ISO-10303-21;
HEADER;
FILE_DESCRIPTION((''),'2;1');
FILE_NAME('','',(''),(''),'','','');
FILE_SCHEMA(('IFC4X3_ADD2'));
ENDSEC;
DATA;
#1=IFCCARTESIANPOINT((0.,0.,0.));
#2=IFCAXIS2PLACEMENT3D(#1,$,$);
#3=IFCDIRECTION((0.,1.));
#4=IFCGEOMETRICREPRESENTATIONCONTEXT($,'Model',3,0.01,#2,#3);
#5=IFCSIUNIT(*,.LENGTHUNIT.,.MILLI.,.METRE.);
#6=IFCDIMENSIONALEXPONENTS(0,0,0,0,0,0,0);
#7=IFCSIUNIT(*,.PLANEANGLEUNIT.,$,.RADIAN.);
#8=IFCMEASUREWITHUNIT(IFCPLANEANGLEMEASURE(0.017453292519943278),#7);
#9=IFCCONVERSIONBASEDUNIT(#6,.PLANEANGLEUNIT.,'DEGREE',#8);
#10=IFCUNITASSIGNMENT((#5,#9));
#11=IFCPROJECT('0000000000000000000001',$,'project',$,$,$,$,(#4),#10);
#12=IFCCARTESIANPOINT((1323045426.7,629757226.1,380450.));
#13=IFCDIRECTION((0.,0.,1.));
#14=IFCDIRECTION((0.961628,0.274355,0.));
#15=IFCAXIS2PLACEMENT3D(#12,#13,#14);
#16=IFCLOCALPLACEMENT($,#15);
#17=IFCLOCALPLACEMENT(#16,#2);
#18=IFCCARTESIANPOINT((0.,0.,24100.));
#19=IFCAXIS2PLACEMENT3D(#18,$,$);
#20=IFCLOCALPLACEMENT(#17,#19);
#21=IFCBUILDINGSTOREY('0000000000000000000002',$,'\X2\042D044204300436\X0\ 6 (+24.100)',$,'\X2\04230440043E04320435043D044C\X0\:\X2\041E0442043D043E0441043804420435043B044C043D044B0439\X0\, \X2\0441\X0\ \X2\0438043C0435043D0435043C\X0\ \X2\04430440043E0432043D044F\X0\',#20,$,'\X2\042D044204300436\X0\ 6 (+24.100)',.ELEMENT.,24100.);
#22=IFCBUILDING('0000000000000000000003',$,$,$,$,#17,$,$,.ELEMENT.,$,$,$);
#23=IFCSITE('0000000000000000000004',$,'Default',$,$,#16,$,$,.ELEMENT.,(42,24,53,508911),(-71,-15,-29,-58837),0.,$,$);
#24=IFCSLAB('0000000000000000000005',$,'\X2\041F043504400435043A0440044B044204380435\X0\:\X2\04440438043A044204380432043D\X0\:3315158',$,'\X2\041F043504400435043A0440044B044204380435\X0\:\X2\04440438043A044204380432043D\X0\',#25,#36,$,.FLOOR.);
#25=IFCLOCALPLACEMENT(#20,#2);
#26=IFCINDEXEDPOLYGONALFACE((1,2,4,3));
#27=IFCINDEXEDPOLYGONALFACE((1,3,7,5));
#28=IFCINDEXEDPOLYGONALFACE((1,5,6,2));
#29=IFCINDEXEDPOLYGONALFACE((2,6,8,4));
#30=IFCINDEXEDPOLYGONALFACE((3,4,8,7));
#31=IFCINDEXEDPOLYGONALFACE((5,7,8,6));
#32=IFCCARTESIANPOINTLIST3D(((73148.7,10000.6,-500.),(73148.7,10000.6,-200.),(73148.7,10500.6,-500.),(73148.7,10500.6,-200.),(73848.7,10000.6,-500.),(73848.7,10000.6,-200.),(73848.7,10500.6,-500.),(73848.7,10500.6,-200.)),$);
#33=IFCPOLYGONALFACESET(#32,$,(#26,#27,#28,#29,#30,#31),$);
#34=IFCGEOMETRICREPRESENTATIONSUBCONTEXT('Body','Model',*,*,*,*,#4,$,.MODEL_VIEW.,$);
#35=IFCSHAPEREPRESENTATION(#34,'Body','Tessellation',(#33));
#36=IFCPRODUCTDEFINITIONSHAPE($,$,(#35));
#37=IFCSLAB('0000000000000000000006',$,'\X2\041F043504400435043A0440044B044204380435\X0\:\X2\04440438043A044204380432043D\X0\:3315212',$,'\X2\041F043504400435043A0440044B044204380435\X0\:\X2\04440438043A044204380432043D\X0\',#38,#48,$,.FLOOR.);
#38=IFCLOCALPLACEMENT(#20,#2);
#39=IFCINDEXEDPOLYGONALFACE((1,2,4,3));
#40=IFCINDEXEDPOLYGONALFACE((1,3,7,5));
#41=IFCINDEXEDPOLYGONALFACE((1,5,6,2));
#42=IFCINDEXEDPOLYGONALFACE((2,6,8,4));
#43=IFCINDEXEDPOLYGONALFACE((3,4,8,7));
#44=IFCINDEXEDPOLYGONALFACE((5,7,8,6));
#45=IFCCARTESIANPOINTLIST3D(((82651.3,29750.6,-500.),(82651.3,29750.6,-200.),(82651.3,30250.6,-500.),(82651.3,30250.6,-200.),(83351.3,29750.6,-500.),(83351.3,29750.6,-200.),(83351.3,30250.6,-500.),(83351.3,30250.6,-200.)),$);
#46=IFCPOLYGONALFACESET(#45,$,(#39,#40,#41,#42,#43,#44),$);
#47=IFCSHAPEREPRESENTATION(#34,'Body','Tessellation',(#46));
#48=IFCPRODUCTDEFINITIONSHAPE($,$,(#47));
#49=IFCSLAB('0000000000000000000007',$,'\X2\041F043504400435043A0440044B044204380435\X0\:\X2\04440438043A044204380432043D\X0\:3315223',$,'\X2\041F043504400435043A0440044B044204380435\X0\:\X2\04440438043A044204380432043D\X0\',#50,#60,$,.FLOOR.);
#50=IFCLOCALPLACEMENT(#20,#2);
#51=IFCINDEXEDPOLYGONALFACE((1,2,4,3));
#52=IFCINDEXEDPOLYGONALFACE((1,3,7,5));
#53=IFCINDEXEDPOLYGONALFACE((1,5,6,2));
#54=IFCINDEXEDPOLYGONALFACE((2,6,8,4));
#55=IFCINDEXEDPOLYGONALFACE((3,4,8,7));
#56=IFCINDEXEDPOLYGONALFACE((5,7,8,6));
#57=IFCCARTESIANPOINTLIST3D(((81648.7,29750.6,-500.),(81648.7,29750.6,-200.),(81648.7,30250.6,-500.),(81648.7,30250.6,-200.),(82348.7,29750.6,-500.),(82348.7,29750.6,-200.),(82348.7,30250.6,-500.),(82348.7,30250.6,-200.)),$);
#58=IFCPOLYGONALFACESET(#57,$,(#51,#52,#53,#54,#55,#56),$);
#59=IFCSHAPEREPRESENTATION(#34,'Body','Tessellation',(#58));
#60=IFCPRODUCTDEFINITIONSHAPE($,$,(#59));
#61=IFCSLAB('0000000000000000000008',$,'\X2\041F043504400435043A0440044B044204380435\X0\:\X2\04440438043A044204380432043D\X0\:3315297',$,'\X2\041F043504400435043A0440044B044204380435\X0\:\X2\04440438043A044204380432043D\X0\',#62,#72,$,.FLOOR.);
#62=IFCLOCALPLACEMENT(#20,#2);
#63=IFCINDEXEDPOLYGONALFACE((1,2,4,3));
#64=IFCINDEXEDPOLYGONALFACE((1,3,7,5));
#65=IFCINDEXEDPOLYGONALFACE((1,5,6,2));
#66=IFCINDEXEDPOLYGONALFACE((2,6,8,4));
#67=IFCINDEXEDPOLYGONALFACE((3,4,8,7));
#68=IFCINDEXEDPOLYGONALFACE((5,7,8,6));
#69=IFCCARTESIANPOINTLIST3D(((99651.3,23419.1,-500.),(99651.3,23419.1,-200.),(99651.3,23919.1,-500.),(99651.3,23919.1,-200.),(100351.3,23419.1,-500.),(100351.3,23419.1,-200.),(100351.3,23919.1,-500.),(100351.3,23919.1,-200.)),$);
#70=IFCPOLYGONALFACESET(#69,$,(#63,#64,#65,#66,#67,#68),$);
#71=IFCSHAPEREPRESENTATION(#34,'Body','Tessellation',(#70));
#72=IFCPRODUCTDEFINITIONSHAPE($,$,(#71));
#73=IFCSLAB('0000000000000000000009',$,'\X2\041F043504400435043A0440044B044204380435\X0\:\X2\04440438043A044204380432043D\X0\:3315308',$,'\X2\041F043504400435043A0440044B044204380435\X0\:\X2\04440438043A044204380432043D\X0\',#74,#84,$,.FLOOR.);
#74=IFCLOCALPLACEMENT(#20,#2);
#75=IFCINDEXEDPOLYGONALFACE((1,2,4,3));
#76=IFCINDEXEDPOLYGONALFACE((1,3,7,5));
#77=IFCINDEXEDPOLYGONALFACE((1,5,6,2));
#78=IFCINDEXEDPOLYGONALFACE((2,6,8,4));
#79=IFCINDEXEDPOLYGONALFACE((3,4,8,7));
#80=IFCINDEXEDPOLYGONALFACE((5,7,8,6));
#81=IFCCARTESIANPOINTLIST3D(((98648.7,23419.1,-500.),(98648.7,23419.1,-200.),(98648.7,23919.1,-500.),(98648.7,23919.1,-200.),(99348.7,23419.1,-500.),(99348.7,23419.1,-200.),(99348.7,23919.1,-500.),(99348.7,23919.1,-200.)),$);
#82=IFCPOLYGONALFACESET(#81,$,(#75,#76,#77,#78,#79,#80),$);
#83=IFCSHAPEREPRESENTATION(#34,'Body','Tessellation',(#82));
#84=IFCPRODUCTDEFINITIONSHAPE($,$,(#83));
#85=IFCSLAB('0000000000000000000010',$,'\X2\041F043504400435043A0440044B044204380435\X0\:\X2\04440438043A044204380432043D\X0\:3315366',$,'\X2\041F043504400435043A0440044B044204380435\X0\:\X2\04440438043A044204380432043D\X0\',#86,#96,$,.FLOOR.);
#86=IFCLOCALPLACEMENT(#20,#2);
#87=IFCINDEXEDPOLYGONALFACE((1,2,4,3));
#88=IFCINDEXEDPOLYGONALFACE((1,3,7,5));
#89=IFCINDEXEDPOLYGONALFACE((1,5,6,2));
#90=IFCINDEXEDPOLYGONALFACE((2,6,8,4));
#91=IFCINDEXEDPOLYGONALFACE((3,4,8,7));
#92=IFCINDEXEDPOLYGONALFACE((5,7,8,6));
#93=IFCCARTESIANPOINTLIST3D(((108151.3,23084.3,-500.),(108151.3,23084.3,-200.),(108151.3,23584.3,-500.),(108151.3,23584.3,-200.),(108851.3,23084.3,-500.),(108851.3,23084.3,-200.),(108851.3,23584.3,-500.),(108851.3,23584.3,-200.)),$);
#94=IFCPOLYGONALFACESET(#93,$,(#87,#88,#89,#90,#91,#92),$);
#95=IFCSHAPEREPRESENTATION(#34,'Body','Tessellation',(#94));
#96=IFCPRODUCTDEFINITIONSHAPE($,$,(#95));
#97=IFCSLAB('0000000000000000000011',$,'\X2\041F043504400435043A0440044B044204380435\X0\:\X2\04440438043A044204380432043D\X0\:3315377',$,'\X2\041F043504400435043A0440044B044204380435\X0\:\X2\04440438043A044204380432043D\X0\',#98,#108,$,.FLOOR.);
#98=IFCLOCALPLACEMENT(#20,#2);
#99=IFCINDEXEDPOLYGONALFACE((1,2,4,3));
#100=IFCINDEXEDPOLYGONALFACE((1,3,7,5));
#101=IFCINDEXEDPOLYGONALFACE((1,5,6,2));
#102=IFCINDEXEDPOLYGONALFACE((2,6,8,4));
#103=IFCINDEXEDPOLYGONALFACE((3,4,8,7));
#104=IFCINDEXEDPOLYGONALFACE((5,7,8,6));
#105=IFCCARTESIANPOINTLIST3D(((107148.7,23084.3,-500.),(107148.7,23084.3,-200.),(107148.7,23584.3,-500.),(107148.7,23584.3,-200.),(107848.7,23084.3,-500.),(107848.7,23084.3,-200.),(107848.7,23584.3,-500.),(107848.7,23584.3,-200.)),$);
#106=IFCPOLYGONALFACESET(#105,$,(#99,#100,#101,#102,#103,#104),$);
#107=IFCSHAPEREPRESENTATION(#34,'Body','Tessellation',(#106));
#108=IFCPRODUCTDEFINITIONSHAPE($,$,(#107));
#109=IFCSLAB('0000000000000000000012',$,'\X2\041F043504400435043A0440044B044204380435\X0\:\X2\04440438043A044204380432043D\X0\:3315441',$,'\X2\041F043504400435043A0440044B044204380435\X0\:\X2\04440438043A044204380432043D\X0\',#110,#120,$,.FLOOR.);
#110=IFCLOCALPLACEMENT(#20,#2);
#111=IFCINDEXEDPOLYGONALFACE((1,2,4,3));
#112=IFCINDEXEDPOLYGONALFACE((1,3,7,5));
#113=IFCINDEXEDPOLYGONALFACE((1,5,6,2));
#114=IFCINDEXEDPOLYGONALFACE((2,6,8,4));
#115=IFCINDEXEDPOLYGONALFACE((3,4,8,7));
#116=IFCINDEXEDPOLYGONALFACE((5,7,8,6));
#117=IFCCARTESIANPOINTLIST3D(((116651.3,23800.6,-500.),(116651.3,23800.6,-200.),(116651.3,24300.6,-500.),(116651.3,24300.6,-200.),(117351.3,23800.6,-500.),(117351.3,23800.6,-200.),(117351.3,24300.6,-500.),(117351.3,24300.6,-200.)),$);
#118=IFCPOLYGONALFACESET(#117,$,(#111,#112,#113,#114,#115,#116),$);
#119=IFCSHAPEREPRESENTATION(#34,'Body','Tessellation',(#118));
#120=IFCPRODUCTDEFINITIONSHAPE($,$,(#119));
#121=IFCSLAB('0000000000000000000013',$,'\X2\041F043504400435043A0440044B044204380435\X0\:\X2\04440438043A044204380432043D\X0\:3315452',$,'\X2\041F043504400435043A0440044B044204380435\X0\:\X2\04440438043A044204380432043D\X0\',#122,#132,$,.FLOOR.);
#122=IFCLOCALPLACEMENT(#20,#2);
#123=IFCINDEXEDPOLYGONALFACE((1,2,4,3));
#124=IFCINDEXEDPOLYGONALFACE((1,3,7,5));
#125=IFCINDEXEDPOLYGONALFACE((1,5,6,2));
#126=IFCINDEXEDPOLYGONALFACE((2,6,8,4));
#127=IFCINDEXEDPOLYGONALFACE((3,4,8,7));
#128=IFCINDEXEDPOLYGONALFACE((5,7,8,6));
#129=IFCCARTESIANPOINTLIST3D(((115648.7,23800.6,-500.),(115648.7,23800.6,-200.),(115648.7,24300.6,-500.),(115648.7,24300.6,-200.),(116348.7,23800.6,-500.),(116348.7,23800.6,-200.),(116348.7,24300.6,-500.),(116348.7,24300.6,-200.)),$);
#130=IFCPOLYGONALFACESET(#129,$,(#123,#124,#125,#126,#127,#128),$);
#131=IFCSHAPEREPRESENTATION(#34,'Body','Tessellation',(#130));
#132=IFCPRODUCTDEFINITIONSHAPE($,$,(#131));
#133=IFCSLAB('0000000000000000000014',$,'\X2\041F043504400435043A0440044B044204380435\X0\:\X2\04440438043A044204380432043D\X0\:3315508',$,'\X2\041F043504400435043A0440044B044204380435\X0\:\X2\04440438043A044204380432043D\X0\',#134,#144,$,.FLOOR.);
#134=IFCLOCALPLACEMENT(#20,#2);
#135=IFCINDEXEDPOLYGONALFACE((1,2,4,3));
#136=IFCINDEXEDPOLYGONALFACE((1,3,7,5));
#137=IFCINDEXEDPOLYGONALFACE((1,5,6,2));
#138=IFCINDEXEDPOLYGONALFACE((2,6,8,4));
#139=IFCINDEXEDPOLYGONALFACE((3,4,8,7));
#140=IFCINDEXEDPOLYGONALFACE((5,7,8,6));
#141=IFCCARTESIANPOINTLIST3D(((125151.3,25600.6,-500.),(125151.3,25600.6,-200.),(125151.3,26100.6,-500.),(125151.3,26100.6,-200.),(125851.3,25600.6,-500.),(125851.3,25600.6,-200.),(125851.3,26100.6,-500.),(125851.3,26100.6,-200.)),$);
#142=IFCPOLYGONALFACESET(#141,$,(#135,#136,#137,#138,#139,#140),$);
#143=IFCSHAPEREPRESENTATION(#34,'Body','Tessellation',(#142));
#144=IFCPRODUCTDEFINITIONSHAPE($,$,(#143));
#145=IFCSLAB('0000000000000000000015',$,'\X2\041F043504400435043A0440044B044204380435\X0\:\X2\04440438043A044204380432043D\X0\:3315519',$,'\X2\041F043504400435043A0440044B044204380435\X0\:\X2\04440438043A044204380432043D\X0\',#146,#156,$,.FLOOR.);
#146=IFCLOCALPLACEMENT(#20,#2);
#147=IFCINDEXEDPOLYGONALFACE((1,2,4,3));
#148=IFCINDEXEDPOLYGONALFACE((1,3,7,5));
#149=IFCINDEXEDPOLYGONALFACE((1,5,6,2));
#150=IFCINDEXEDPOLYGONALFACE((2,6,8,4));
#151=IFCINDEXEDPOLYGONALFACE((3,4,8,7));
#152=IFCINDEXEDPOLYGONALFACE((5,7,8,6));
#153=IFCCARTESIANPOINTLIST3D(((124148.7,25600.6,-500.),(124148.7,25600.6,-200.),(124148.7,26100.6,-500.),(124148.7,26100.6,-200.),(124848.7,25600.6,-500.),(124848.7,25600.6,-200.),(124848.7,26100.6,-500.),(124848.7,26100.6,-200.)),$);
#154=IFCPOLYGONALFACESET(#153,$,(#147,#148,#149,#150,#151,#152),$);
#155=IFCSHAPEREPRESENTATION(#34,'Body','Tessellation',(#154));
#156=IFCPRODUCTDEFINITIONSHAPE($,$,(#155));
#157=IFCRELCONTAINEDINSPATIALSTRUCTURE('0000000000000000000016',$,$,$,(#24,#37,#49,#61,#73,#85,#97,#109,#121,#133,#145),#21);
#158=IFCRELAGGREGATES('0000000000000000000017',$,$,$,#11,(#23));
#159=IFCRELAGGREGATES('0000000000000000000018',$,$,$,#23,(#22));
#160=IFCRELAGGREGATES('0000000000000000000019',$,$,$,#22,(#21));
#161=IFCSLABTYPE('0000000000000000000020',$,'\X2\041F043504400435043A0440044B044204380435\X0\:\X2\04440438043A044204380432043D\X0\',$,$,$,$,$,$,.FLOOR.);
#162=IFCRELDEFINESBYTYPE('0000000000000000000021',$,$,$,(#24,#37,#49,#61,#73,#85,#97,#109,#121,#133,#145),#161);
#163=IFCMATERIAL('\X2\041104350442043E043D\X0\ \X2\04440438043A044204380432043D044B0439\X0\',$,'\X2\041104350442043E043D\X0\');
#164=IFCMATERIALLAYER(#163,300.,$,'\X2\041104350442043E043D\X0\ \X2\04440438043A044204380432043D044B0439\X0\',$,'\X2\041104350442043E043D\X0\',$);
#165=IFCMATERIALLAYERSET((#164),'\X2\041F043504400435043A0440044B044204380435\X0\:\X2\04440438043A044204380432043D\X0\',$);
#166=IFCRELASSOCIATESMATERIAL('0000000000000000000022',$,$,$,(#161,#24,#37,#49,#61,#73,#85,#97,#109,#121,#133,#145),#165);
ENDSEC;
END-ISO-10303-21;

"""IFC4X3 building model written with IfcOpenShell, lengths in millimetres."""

from ifc_helpers import new_model, entity, si_unit, converted_unit, direction, frame, frame_2d, origin, place, context, subcontext, project, spatial, rectangle, extrude, material, layer, layer_set, layer_usage, type_object, element, save


model = new_model("IFC4X3")

# Units and contexts
model_context = context("Model", 3, precision=0.01, world=origin(), true_north=direction((0.0, 1.0)))
body_context = subcontext(model_context, "Body", "Model", "MODEL_VIEW")
ifc_project = project(units=[si_unit("LENGTHUNIT", "METRE", prefix="MILLI"), converted_unit("PLANEANGLEUNIT", "DEGREE", entity("IfcPlaneAngleMeasure", 0.017453292519943278), si_unit("PLANEANGLEUNIT", "RADIAN"), dimensions=[0, 0, 0, 0, 0, 0, 0])], contexts=[model_context])

# Site, building, storey
site_placement = place(None, frame((1323045426.7, 629757226.1, 380450.0), z_axis=(0.0, 0.0, 1.0), x_axis=(0.961628, 0.274355, 0.0)))
site = spatial("IfcSite", under=ifc_project, at=site_placement, Name="Default", CompositionType="ELEMENT", RefLatitude=(42, 24, 53, 508911), RefLongitude=(-71, -15, -29, -58837), RefElevation=0.0)
building_placement = place(site_placement, origin())
building = spatial("IfcBuilding", under=site, at=building_placement, CompositionType="ELEMENT")
storey_placement = place(building_placement, frame((0.0, 0.0, 24100.0)))
storey = spatial("IfcBuildingStorey", under=building, at=storey_placement, Name="Этаж 6 (+24.100)", ObjectType="Уровень:Относительный, с именем уровня", LongName="Этаж 6 (+24.100)", CompositionType="ELEMENT", Elevation=24100.0)

# Slabs
ifc_material = material(Name="Бетон фиктивный", Category="Бетон")
ifc_layer = layer(ifc_material, 300.0, Name="Бетон фиктивный", Category="Бетон")
ifc_layer_set = layer_set([ifc_layer], Name="Перекрытие:фиктивн")
slab_type = type_object("IfcSlabType", Name="Перекрытие:фиктивн", PredefinedType="FLOOR", material=ifc_layer_set)
ifc_layer_usage_1 = layer_usage(ifc_layer_set, "AXIS3", "POSITIVE", 0.0)
slab_1_placement = place(storey_placement, origin())
element("IfcSlab", 1, at=slab_1_placement, inside=storey, type_object=slab_type, material=ifc_layer_usage_1, Name="Перекрытие:фиктивн:3315158", ObjectType="Перекрытие:фиктивн", PredefinedType="FLOOR", context=body_context, shape_type="SweptSolid", body=[
    extrude(rectangle(XDim=500.0, YDim=700.0, at=frame_2d((0.0, 0.0), x_axis=(1.0, 0.0))), frame((73498.7, 10250.6, -200.0), z_axis=(0.0, 0.0, -1.0), x_axis=(0.0, 1.0, 0.0)), (0.0, 0.0, 1.0), 300.0),
])
ifc_layer_usage_2 = layer_usage(ifc_layer_set, "AXIS3", "POSITIVE", 0.0)
slab_2_placement = place(storey_placement, origin())
element("IfcSlab", 2, at=slab_2_placement, inside=storey, type_object=slab_type, material=ifc_layer_usage_2, Name="Перекрытие:фиктивн:3315212", ObjectType="Перекрытие:фиктивн", PredefinedType="FLOOR", context=body_context, shape_type="SweptSolid", body=[
    extrude(rectangle(XDim=500.0, YDim=700.0, at=frame_2d((0.0, 0.0), x_axis=(1.0, 0.0))), frame((83001.3, 30000.6, -200.0), z_axis=(0.0, 0.0, -1.0), x_axis=(0.0, 1.0, 0.0)), (0.0, 0.0, 1.0), 300.0),
])
ifc_layer_usage_3 = layer_usage(ifc_layer_set, "AXIS3", "POSITIVE", 0.0)
slab_3_placement = place(storey_placement, origin())
element("IfcSlab", 3, at=slab_3_placement, inside=storey, type_object=slab_type, material=ifc_layer_usage_3, Name="Перекрытие:фиктивн:3315223", ObjectType="Перекрытие:фиктивн", PredefinedType="FLOOR", context=body_context, shape_type="SweptSolid", body=[
    extrude(rectangle(XDim=500.0, YDim=700.0, at=frame_2d((0.0, 0.0), x_axis=(1.0, 0.0))), frame((81998.7, 30000.6, -200.0), z_axis=(0.0, 0.0, -1.0), x_axis=(0.0, 1.0, 0.0)), (0.0, 0.0, 1.0), 300.0),
])
ifc_layer_usage_4 = layer_usage(ifc_layer_set, "AXIS3", "POSITIVE", 0.0)
slab_4_placement = place(storey_placement, origin())
element("IfcSlab", 4, at=slab_4_placement, inside=storey, type_object=slab_type, material=ifc_layer_usage_4, Name="Перекрытие:фиктивн:3315297", ObjectType="Перекрытие:фиктивн", PredefinedType="FLOOR", context=body_context, shape_type="SweptSolid", body=[
    extrude(rectangle(XDim=500.0, YDim=700.0, at=frame_2d((0.0, 0.0), x_axis=(1.0, 0.0))), frame((100001.3, 23669.1, -200.0), z_axis=(0.0, 0.0, -1.0), x_axis=(0.0, 1.0, 0.0)), (0.0, 0.0, 1.0), 300.0),
])
ifc_layer_usage_5 = layer_usage(ifc_layer_set, "AXIS3", "POSITIVE", 0.0)
slab_5_placement = place(storey_placement, origin())
element("IfcSlab", 5, at=slab_5_placement, inside=storey, type_object=slab_type, material=ifc_layer_usage_5, Name="Перекрытие:фиктивн:3315308", ObjectType="Перекрытие:фиктивн", PredefinedType="FLOOR", context=body_context, shape_type="SweptSolid", body=[
    extrude(rectangle(XDim=500.0, YDim=700.0, at=frame_2d((0.0, 0.0), x_axis=(1.0, 0.0))), frame((98998.7, 23669.1, -200.0), z_axis=(0.0, 0.0, -1.0), x_axis=(0.0, 1.0, 0.0)), (0.0, 0.0, 1.0), 300.0),
])
ifc_layer_usage_6 = layer_usage(ifc_layer_set, "AXIS3", "POSITIVE", 0.0)
slab_6_placement = place(storey_placement, origin())
element("IfcSlab", 6, at=slab_6_placement, inside=storey, type_object=slab_type, material=ifc_layer_usage_6, Name="Перекрытие:фиктивн:3315366", ObjectType="Перекрытие:фиктивн", PredefinedType="FLOOR", context=body_context, shape_type="SweptSolid", body=[
    extrude(rectangle(XDim=500.0, YDim=700.0, at=frame_2d((0.0, 0.0), x_axis=(1.0, 0.0))), frame((108501.3, 23334.3, -200.0), z_axis=(0.0, 0.0, -1.0), x_axis=(0.0, 1.0, 0.0)), (0.0, 0.0, 1.0), 300.0),
])
ifc_layer_usage_7 = layer_usage(ifc_layer_set, "AXIS3", "POSITIVE", 0.0)
slab_7_placement = place(storey_placement, origin())
element("IfcSlab", 7, at=slab_7_placement, inside=storey, type_object=slab_type, material=ifc_layer_usage_7, Name="Перекрытие:фиктивн:3315377", ObjectType="Перекрытие:фиктивн", PredefinedType="FLOOR", context=body_context, shape_type="SweptSolid", body=[
    extrude(rectangle(XDim=500.0, YDim=700.0, at=frame_2d((0.0, 0.0), x_axis=(1.0, 0.0))), frame((107498.7, 23334.3, -200.0), z_axis=(0.0, 0.0, -1.0), x_axis=(0.0, 1.0, 0.0)), (0.0, 0.0, 1.0), 300.0),
])
ifc_layer_usage_8 = layer_usage(ifc_layer_set, "AXIS3", "POSITIVE", 0.0)
slab_8_placement = place(storey_placement, origin())
element("IfcSlab", 8, at=slab_8_placement, inside=storey, type_object=slab_type, material=ifc_layer_usage_8, Name="Перекрытие:фиктивн:3315441", ObjectType="Перекрытие:фиктивн", PredefinedType="FLOOR", context=body_context, shape_type="SweptSolid", body=[
    extrude(rectangle(XDim=500.0, YDim=700.0, at=frame_2d((0.0, 0.0), x_axis=(1.0, 0.0))), frame((117001.3, 24050.6, -200.0), z_axis=(0.0, 0.0, -1.0), x_axis=(0.0, 1.0, 0.0)), (0.0, 0.0, 1.0), 300.0),
])
ifc_layer_usage_9 = layer_usage(ifc_layer_set, "AXIS3", "POSITIVE", 0.0)
slab_9_placement = place(storey_placement, origin())
element("IfcSlab", 9, at=slab_9_placement, inside=storey, type_object=slab_type, material=ifc_layer_usage_9, Name="Перекрытие:фиктивн:3315452", ObjectType="Перекрытие:фиктивн", PredefinedType="FLOOR", context=body_context, shape_type="SweptSolid", body=[
    extrude(rectangle(XDim=500.0, YDim=700.0, at=frame_2d((0.0, 0.0), x_axis=(1.0, 0.0))), frame((115998.7, 24050.6, -200.0), z_axis=(0.0, 0.0, -1.0), x_axis=(0.0, 1.0, 0.0)), (0.0, 0.0, 1.0), 300.0),
])
ifc_layer_usage_10 = layer_usage(ifc_layer_set, "AXIS3", "POSITIVE", 0.0)
slab_10_placement = place(storey_placement, origin())
element("IfcSlab", 10, at=slab_10_placement, inside=storey, type_object=slab_type, material=ifc_layer_usage_10, Name="Перекрытие:фиктивн:3315508", ObjectType="Перекрытие:фиктивн", PredefinedType="FLOOR", context=body_context, shape_type="SweptSolid", body=[
    extrude(rectangle(XDim=500.0, YDim=700.0, at=frame_2d((0.0, 0.0), x_axis=(1.0, 0.0))), frame((125501.3, 25850.6, -200.0), z_axis=(0.0, 0.0, -1.0), x_axis=(0.0, 1.0, 0.0)), (0.0, 0.0, 1.0), 300.0),
])
ifc_layer_usage_11 = layer_usage(ifc_layer_set, "AXIS3", "POSITIVE", 0.0)
slab_11_placement = place(storey_placement, origin())
element("IfcSlab", 11, at=slab_11_placement, inside=storey, type_object=slab_type, material=ifc_layer_usage_11, Name="Перекрытие:фиктивн:3315519", ObjectType="Перекрытие:фиктивн", PredefinedType="FLOOR", context=body_context, shape_type="SweptSolid", body=[
    extrude(rectangle(XDim=500.0, YDim=700.0, at=frame_2d((0.0, 0.0), x_axis=(1.0, 0.0))), frame((124498.7, 25850.6, -200.0), z_axis=(0.0, 0.0, -1.0), x_axis=(0.0, 1.0, 0.0)), (0.0, 0.0, 1.0), 300.0),
])

save(model, "model.ifc")
